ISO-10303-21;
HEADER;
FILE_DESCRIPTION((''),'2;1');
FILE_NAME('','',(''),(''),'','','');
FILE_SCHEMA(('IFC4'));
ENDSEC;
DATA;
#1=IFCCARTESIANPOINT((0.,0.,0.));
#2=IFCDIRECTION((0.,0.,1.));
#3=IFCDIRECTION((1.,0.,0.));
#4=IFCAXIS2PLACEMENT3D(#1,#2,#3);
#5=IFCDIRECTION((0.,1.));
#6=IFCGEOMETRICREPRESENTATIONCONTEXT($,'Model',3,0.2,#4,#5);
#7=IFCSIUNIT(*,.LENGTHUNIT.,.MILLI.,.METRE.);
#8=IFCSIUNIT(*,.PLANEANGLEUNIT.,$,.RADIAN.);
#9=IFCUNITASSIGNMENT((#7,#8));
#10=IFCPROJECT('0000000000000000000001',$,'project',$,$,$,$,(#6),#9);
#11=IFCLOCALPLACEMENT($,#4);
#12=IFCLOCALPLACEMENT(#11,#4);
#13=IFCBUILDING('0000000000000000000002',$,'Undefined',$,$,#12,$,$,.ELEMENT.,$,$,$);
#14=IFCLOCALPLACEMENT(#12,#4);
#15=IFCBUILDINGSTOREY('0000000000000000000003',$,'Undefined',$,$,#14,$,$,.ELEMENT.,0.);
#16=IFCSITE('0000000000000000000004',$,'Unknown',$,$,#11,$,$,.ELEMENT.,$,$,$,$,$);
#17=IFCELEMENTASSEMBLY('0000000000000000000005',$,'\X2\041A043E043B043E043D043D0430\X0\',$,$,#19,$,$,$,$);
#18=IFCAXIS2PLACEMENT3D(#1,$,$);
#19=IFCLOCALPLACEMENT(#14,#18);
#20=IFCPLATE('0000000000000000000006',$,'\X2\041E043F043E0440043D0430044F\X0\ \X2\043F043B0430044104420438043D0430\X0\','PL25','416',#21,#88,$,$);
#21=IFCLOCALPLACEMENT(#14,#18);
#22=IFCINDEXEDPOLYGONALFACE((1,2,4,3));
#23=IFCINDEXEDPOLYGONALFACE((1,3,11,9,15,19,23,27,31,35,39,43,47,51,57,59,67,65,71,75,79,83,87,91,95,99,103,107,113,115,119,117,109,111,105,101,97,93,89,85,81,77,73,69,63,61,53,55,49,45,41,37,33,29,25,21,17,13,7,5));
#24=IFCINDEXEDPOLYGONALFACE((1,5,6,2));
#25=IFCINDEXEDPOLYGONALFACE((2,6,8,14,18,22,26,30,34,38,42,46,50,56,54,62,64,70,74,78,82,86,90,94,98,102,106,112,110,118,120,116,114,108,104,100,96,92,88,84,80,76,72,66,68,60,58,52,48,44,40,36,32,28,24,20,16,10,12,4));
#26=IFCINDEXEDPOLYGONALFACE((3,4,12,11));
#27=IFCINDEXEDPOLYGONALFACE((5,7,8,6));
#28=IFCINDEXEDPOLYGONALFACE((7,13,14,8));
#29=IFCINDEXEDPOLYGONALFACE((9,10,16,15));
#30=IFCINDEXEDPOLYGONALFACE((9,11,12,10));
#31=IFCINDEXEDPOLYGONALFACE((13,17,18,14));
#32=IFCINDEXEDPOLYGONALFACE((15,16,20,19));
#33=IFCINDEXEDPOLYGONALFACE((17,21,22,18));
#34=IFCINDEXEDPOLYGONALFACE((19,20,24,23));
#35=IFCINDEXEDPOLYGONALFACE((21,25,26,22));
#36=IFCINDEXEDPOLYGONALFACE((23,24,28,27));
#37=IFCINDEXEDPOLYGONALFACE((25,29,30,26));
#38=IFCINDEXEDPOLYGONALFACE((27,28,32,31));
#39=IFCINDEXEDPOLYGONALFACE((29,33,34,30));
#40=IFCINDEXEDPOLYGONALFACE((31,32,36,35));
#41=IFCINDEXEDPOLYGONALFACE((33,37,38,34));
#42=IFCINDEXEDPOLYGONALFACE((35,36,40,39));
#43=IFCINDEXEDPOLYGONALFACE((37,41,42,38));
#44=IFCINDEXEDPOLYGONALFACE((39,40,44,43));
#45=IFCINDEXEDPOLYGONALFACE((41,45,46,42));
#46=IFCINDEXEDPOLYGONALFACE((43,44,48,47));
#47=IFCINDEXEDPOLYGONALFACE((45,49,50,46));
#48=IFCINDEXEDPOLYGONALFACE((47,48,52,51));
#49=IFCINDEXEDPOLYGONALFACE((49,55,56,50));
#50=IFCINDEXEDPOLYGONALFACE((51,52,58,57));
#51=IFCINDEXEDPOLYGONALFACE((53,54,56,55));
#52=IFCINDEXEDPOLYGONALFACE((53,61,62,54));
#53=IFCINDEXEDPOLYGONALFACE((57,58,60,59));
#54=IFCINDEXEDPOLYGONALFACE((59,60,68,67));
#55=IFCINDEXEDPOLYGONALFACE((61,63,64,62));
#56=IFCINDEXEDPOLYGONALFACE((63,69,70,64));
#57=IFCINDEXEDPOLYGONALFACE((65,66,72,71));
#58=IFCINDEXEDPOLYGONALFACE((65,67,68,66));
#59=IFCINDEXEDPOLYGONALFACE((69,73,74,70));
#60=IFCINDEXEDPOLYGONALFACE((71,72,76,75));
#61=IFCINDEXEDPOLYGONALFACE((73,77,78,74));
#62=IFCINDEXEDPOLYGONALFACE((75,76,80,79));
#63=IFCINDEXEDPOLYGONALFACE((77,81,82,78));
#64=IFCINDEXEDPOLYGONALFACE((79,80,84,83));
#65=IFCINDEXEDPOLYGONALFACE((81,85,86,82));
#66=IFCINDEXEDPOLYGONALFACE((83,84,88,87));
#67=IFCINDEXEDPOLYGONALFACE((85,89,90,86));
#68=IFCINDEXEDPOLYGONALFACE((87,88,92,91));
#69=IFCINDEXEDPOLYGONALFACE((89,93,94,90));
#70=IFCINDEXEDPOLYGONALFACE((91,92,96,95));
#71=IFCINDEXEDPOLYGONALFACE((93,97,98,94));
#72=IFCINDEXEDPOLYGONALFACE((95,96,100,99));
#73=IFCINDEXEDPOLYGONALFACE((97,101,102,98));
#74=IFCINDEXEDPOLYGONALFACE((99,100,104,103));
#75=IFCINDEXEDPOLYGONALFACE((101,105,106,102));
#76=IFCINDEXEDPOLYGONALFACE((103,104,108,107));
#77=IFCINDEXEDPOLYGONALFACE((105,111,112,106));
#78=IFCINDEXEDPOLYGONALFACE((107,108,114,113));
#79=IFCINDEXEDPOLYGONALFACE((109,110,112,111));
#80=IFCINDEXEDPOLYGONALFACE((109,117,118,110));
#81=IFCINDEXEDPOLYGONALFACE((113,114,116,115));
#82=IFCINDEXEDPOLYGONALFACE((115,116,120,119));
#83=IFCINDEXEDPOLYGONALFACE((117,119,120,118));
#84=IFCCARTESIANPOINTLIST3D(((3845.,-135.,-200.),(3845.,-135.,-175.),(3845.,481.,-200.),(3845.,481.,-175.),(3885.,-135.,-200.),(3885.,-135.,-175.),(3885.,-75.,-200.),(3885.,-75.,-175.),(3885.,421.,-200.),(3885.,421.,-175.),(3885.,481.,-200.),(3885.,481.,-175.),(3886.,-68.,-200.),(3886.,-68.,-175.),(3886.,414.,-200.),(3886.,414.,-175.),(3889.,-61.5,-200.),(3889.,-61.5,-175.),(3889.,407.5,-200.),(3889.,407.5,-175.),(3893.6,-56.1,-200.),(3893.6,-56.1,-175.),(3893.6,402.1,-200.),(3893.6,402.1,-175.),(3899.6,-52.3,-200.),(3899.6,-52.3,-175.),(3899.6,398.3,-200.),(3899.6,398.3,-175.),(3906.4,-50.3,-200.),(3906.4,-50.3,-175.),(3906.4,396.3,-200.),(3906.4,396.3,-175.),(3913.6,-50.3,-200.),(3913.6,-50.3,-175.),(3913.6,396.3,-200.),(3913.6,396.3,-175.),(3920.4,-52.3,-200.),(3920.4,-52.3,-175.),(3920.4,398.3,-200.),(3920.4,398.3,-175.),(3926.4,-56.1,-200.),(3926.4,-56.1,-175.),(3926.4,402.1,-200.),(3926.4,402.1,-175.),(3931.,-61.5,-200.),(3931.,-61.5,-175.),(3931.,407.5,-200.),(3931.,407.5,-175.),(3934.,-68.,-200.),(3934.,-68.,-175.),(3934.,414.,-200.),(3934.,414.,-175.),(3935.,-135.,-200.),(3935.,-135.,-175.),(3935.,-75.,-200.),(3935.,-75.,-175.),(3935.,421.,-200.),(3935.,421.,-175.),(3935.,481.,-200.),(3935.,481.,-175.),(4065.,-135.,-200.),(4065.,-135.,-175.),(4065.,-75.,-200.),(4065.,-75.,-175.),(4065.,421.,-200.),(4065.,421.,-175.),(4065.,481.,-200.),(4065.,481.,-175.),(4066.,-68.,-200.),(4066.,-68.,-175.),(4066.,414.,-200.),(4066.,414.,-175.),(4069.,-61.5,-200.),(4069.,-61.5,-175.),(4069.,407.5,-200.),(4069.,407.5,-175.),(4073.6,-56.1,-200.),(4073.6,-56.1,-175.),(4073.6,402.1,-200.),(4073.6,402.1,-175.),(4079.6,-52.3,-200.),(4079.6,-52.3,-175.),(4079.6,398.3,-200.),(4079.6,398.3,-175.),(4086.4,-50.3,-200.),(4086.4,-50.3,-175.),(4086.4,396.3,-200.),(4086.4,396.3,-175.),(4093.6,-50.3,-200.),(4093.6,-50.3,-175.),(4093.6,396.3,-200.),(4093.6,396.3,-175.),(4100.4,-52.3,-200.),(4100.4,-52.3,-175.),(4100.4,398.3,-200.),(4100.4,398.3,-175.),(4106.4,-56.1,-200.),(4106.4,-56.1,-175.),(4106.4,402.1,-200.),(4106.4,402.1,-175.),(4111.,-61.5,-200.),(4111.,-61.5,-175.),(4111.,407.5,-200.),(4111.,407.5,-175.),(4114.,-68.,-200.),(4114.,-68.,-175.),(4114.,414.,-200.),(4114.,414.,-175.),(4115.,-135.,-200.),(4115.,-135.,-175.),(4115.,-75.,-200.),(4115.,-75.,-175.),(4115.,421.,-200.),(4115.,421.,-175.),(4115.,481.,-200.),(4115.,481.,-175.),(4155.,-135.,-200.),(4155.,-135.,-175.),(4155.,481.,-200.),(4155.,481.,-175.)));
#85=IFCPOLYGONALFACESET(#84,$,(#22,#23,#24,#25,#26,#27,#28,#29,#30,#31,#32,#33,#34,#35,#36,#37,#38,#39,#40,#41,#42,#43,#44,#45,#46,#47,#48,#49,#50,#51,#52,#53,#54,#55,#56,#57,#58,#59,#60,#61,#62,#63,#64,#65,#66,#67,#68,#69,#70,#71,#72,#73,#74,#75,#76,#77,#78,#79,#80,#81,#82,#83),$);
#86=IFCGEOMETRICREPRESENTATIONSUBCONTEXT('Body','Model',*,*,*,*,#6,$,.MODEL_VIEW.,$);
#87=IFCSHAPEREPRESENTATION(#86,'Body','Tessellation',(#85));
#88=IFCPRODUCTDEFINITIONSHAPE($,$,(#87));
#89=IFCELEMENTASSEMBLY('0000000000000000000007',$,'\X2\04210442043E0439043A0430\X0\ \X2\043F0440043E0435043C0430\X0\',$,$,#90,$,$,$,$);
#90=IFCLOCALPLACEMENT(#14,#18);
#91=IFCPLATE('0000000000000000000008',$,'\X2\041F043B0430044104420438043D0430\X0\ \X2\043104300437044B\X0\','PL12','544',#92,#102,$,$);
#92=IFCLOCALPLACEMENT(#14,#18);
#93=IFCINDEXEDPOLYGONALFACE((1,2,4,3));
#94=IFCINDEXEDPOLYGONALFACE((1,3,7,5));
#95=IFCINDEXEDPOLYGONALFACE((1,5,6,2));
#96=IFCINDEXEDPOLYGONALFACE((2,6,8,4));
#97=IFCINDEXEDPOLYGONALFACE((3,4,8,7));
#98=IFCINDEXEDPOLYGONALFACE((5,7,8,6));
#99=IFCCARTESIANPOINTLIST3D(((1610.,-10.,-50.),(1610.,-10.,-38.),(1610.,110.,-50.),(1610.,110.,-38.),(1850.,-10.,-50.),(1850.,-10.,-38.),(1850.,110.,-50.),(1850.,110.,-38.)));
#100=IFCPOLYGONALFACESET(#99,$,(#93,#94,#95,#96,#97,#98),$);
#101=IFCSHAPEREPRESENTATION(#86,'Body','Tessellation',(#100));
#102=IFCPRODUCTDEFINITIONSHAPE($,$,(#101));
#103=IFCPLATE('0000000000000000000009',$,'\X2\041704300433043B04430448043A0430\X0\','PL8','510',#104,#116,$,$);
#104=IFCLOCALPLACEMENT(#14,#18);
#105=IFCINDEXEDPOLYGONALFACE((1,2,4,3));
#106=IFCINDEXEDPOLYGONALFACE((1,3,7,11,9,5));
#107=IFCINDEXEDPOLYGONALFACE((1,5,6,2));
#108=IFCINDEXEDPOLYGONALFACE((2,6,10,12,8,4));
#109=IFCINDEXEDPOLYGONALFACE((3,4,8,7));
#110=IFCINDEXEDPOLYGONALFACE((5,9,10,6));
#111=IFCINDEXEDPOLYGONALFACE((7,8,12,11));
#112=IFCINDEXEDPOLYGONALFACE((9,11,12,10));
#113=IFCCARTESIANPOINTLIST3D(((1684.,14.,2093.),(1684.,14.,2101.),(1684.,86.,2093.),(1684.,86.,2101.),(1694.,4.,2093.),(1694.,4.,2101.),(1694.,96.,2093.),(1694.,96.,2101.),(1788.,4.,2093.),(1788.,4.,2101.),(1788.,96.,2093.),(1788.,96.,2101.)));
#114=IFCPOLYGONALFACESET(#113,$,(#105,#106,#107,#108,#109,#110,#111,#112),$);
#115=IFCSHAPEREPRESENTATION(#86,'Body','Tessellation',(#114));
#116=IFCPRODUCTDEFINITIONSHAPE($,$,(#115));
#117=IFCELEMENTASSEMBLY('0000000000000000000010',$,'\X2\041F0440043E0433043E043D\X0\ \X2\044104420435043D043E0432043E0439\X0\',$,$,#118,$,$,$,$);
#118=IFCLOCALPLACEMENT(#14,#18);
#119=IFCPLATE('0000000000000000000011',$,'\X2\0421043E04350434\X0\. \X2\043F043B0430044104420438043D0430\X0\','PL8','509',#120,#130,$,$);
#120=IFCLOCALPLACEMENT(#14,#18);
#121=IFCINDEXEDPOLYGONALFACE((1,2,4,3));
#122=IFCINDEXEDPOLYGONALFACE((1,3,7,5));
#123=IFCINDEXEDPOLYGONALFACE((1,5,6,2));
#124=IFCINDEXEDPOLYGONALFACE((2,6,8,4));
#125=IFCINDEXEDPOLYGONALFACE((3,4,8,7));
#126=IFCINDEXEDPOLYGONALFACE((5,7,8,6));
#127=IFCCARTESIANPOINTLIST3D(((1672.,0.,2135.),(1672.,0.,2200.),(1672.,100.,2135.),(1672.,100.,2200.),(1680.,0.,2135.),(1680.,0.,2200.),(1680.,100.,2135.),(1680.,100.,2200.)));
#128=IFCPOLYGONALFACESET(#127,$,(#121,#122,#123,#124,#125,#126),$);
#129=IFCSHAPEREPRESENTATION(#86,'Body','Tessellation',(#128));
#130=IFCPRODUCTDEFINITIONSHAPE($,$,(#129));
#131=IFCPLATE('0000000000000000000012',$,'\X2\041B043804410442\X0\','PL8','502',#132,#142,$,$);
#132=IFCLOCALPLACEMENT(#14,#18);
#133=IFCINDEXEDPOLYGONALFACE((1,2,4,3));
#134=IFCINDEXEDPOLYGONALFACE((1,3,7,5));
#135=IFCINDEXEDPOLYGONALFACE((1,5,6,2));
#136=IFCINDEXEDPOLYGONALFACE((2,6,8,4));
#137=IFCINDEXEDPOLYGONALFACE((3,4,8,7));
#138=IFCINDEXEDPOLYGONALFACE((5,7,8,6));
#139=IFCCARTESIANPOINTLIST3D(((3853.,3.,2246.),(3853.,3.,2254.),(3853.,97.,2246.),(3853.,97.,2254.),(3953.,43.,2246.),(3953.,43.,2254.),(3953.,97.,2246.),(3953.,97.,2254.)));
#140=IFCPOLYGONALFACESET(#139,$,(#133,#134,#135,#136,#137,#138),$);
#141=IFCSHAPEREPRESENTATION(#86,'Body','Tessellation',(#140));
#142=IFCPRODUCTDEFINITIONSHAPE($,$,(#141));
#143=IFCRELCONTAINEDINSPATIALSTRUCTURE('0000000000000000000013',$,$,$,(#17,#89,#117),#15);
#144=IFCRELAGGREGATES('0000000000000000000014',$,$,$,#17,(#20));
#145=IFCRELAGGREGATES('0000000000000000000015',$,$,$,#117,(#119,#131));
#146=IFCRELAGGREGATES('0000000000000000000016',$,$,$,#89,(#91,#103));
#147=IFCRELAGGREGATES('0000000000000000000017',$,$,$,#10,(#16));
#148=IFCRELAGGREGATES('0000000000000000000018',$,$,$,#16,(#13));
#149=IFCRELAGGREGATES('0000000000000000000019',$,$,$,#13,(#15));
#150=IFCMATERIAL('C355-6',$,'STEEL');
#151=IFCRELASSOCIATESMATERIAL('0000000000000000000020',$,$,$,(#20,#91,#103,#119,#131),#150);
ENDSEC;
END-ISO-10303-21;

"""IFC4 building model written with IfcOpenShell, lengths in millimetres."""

from ifc_helpers import new_model, si_unit, direction, frame, origin_with_axes, place, context, subcontext, project, spatial, line, arc, indexed_curve, outline, extrude, material, element, aggregate, save


model = new_model("IFC4")

# Units and contexts
model_context = context("Model", 3, precision=0.2, world=origin_with_axes(), true_north=direction((0.0, 1.0)))
body_context = subcontext(model_context, "Body", "Model", "MODEL_VIEW")
ifc_project = project(units=[si_unit("LENGTHUNIT", "METRE", prefix="MILLI"), si_unit("PLANEANGLEUNIT", "RADIAN")], contexts=[model_context])

# Site, building, storey
site_placement = place(None, origin_with_axes())
site = spatial("IfcSite", under=ifc_project, at=site_placement, Name="Unknown", CompositionType="ELEMENT")
building_placement = place(site_placement, origin_with_axes())
building = spatial("IfcBuilding", under=site, at=building_placement, Name="Undefined", CompositionType="ELEMENT")
storey_placement = place(building_placement, origin_with_axes())
storey = spatial("IfcBuildingStorey", under=building, at=storey_placement, Name="Undefined", CompositionType="ELEMENT", Elevation=0.0)

# Element assembly, plate, voiding features
assembly_1_placement = place(storey_placement, frame((4000.0, 173.0, -200.0), z_axis=(-1.0, 0.0, 0.0), x_axis=(0.0, 0.0, 1.0)))
assembly_1 = element("IfcElementAssembly", 1, at=assembly_1_placement, inside=storey, Name="Колонна")
ifc_material_1 = material(Name="C355-6", Category="STEEL")
plate_1_placement = place(assembly_1_placement, frame((12.5, -308.0, 155.0), z_axis=(1.0, 0.0, 0.0), x_axis=(0.0, 0.0, -1.0)))
plate_1 = element("IfcPlate", 2, at=plate_1_placement, material=ifc_material_1, Name="Опорная пластина", Description="PL25", ObjectType="416", context=body_context, shape_type="SolidModel", body=[
    extrude(outline(indexed_curve([(0.0, 0.0), (310.0, 0.0), (310.0, 616.0), (0.0, 616.0)], segments=[line(1, 2, 3, 4, 1)])), frame((0.0, 0.0, 12.5), z_axis=(0.0, 0.0, 1.0), x_axis=(1.0, 0.0, 0.0)), (0.0, 0.0, -1.0), 25.0),
])
voiding_feature_1_placement = place(plate_1_placement, frame((40.0, 616.0, 0.0), z_axis=(0.0, 0.0, -1.0), x_axis=(1.0, 0.0, 0.0)))
element("IfcVoidingFeature", 3, at=voiding_feature_1_placement, cuts=plate_1, Name="Пластина", ObjectType="(?)", PredefinedType="HOLE", context=body_context, shape_type="SolidModel", body=[
    extrude(outline(indexed_curve([(0.0, 0.0), (50.0, 0.0), (50.0, 60.0), (42.7, 77.7), (25.0, 85.0), (25.0, 85.0), (7.3, 77.7), (0.0, 60.0)], segments=[line(1, 2, 3), arc(3, 4, 5), line(5, 6), arc(6, 7, 8), line(8, 1)])), frame((0.0, 0.0, 12.5), z_axis=(0.0, 0.0, 1.0), x_axis=(1.0, 0.0, 0.0)), (0.0, 0.0, -1.0), 25.0),
])
voiding_feature_2_placement = place(plate_1_placement, frame((40.0, 0.0, 0.0), z_axis=(0.0, 0.0, 1.0), x_axis=(1.0, 0.0, 0.0)))
element("IfcVoidingFeature", 4, at=voiding_feature_2_placement, cuts=plate_1, Name="Пластина", ObjectType="(?)", PredefinedType="HOLE", context=body_context, shape_type="SolidModel", body=[
    extrude(outline(indexed_curve([(0.0, 0.0), (50.0, 0.0), (50.0, 60.0), (42.7, 77.7), (25.0, 85.0), (25.0, 85.0), (7.3, 77.7), (0.0, 60.0)], segments=[line(1, 2, 3), arc(3, 4, 5), line(5, 6), arc(6, 7, 8), line(8, 1)])), frame((0.0, 0.0, 12.5), z_axis=(0.0, 0.0, 1.0), x_axis=(1.0, 0.0, 0.0)), (0.0, 0.0, -1.0), 25.0),
])
voiding_feature_3_placement = place(plate_1_placement, frame((270.0, 616.0, 0.0), z_axis=(0.0, 0.0, 1.0), x_axis=(-1.0, 0.0, 0.0)))
element("IfcVoidingFeature", 5, at=voiding_feature_3_placement, cuts=plate_1, Name="Пластина", ObjectType="(?)", PredefinedType="HOLE", context=body_context, shape_type="SolidModel", body=[
    extrude(outline(indexed_curve([(0.0, 0.0), (50.0, 0.0), (50.0, 60.0), (42.7, 77.7), (25.0, 85.0), (25.0, 85.0), (7.3, 77.7), (0.0, 60.0)], segments=[line(1, 2, 3), arc(3, 4, 5), line(5, 6), arc(6, 7, 8), line(8, 1)])), frame((0.0, 0.0, 12.5), z_axis=(0.0, 0.0, 1.0), x_axis=(1.0, 0.0, 0.0)), (0.0, 0.0, -1.0), 25.0),
])
voiding_feature_4_placement = place(plate_1_placement, frame((270.0, 0.0, 0.0), z_axis=(0.0, 0.0, -1.0), x_axis=(-1.0, 0.0, 0.0)))
element("IfcVoidingFeature", 6, at=voiding_feature_4_placement, cuts=plate_1, Name="Пластина", ObjectType="(?)", PredefinedType="HOLE", context=body_context, shape_type="SolidModel", body=[
    extrude(outline(indexed_curve([(0.0, 0.0), (50.0, 0.0), (50.0, 60.0), (42.7, 77.7), (25.0, 85.0), (25.0, 85.0), (7.3, 77.7), (0.0, 60.0)], segments=[line(1, 2, 3), arc(3, 4, 5), line(5, 6), arc(6, 7, 8), line(8, 1)])), frame((0.0, 0.0, 12.5), z_axis=(0.0, 0.0, 1.0), x_axis=(1.0, 0.0, 0.0)), (0.0, 0.0, -1.0), 25.0),
])
aggregate(assembly_1, [plate_1])

# Element assemblies, plates
assembly_2_placement = place(storey_placement, frame((1730.0, 50.0, -50.0), z_axis=(1.0, 0.0, 0.0), x_axis=(0.0, 0.0, 1.0)))
assembly_2 = element("IfcElementAssembly", 7, at=assembly_2_placement, inside=storey, Name="Стойка проема")
plate_2_placement = place(assembly_2_placement, frame((6.0, -60.0, 120.0), z_axis=(1.0, 0.0, 0.0), x_axis=(0.0, 0.0, -1.0)))
plate_2 = element("IfcPlate", 8, at=plate_2_placement, material=ifc_material_1, Name="Пластина базы", Description="PL12", ObjectType="544", context=body_context, shape_type="SolidModel", body=[
    extrude(outline(indexed_curve([(0.0, 0.0), (240.0, 0.0), (240.0, 120.0), (0.0, 120.0)], segments=[line(1, 2, 3, 4, 1)])), frame((0.0, 0.0, 6.0), z_axis=(0.0, 0.0, 1.0), x_axis=(1.0, 0.0, 0.0)), (0.0, 0.0, -1.0), 12.0),
])
plate_3_placement = place(assembly_2_placement, frame((2147.0, -46.0, -46.0), z_axis=(1.0, 0.0, 0.0), x_axis=(0.0, 1.0, 0.0)))
plate_3 = element("IfcPlate", 9, at=plate_3_placement, material=ifc_material_1, Name="Заглушка", Description="PL8", ObjectType="510", context=body_context, shape_type="SolidModel", body=[
    extrude(outline(indexed_curve([(0.0, 10.0), (10.0, 0.0), (82.0, 0.0), (92.0, 10.0), (92.0, 104.0), (0.0, 104.0)], segments=[line(1, 2, 3, 4, 5, 6, 1)])), frame((0.0, 0.0, 4.0), z_axis=(0.0, 0.0, 1.0), x_axis=(1.0, 0.0, 0.0)), (0.0, 0.0, -1.0), 8.0),
])
assembly_3_placement = place(storey_placement, frame((80.0, 50.0, 2250.0), z_axis=(0.0, 0.0, -1.0), x_axis=(1.0, 0.0, 0.0)))
assembly_3 = element("IfcElementAssembly", 10, at=assembly_3_placement, inside=storey, Name="Прогон стеновой")
plate_4_placement = place(assembly_3_placement, frame((1596.0, -50.0, 50.0), z_axis=(-1.0, 0.0, 0.0), x_axis=(0.0, 0.0, 1.0)))
plate_4 = element("IfcPlate", 11, at=plate_4_placement, material=ifc_material_1, Name="Соед. пластина", Description="PL8", ObjectType="509", context=body_context, shape_type="SolidModel", body=[
    extrude(outline(indexed_curve([(0.0, 0.0), (65.0, 0.0), (65.0, 100.0), (0.0, 100.0)], segments=[line(1, 2, 3, 4, 1)])), frame((0.0, 0.0, 4.0), z_axis=(0.0, 0.0, 1.0), x_axis=(1.0, 0.0, 0.0)), (0.0, 0.0, -1.0), 8.0),
])
plate_5_placement = place(assembly_3_placement, frame((3773.0, 47.0, 0.0), z_axis=(0.0, 0.0, 1.0), x_axis=(0.0, -1.0, 0.0)))
plate_5 = element("IfcPlate", 12, at=plate_5_placement, material=ifc_material_1, Name="Лист", Description="PL8", ObjectType="502", context=body_context, shape_type="SolidModel", body=[
    extrude(outline(indexed_curve([(0.0, 0.0), (94.0, 0.0), (94.0, 100.0), (40.0, 100.0), (0.0, 0.0)], segments=[line(1, 2, 3, 4, 5, 1)])), frame((0.0, 0.0, 4.0), z_axis=(0.0, 0.0, 1.0), x_axis=(1.0, 0.0, 0.0)), (0.0, 0.0, -1.0), 8.0),
])
aggregate(assembly_3, [plate_4, plate_5])

aggregate(assembly_2, [plate_2, plate_3])

save(model, "model.ifc")
